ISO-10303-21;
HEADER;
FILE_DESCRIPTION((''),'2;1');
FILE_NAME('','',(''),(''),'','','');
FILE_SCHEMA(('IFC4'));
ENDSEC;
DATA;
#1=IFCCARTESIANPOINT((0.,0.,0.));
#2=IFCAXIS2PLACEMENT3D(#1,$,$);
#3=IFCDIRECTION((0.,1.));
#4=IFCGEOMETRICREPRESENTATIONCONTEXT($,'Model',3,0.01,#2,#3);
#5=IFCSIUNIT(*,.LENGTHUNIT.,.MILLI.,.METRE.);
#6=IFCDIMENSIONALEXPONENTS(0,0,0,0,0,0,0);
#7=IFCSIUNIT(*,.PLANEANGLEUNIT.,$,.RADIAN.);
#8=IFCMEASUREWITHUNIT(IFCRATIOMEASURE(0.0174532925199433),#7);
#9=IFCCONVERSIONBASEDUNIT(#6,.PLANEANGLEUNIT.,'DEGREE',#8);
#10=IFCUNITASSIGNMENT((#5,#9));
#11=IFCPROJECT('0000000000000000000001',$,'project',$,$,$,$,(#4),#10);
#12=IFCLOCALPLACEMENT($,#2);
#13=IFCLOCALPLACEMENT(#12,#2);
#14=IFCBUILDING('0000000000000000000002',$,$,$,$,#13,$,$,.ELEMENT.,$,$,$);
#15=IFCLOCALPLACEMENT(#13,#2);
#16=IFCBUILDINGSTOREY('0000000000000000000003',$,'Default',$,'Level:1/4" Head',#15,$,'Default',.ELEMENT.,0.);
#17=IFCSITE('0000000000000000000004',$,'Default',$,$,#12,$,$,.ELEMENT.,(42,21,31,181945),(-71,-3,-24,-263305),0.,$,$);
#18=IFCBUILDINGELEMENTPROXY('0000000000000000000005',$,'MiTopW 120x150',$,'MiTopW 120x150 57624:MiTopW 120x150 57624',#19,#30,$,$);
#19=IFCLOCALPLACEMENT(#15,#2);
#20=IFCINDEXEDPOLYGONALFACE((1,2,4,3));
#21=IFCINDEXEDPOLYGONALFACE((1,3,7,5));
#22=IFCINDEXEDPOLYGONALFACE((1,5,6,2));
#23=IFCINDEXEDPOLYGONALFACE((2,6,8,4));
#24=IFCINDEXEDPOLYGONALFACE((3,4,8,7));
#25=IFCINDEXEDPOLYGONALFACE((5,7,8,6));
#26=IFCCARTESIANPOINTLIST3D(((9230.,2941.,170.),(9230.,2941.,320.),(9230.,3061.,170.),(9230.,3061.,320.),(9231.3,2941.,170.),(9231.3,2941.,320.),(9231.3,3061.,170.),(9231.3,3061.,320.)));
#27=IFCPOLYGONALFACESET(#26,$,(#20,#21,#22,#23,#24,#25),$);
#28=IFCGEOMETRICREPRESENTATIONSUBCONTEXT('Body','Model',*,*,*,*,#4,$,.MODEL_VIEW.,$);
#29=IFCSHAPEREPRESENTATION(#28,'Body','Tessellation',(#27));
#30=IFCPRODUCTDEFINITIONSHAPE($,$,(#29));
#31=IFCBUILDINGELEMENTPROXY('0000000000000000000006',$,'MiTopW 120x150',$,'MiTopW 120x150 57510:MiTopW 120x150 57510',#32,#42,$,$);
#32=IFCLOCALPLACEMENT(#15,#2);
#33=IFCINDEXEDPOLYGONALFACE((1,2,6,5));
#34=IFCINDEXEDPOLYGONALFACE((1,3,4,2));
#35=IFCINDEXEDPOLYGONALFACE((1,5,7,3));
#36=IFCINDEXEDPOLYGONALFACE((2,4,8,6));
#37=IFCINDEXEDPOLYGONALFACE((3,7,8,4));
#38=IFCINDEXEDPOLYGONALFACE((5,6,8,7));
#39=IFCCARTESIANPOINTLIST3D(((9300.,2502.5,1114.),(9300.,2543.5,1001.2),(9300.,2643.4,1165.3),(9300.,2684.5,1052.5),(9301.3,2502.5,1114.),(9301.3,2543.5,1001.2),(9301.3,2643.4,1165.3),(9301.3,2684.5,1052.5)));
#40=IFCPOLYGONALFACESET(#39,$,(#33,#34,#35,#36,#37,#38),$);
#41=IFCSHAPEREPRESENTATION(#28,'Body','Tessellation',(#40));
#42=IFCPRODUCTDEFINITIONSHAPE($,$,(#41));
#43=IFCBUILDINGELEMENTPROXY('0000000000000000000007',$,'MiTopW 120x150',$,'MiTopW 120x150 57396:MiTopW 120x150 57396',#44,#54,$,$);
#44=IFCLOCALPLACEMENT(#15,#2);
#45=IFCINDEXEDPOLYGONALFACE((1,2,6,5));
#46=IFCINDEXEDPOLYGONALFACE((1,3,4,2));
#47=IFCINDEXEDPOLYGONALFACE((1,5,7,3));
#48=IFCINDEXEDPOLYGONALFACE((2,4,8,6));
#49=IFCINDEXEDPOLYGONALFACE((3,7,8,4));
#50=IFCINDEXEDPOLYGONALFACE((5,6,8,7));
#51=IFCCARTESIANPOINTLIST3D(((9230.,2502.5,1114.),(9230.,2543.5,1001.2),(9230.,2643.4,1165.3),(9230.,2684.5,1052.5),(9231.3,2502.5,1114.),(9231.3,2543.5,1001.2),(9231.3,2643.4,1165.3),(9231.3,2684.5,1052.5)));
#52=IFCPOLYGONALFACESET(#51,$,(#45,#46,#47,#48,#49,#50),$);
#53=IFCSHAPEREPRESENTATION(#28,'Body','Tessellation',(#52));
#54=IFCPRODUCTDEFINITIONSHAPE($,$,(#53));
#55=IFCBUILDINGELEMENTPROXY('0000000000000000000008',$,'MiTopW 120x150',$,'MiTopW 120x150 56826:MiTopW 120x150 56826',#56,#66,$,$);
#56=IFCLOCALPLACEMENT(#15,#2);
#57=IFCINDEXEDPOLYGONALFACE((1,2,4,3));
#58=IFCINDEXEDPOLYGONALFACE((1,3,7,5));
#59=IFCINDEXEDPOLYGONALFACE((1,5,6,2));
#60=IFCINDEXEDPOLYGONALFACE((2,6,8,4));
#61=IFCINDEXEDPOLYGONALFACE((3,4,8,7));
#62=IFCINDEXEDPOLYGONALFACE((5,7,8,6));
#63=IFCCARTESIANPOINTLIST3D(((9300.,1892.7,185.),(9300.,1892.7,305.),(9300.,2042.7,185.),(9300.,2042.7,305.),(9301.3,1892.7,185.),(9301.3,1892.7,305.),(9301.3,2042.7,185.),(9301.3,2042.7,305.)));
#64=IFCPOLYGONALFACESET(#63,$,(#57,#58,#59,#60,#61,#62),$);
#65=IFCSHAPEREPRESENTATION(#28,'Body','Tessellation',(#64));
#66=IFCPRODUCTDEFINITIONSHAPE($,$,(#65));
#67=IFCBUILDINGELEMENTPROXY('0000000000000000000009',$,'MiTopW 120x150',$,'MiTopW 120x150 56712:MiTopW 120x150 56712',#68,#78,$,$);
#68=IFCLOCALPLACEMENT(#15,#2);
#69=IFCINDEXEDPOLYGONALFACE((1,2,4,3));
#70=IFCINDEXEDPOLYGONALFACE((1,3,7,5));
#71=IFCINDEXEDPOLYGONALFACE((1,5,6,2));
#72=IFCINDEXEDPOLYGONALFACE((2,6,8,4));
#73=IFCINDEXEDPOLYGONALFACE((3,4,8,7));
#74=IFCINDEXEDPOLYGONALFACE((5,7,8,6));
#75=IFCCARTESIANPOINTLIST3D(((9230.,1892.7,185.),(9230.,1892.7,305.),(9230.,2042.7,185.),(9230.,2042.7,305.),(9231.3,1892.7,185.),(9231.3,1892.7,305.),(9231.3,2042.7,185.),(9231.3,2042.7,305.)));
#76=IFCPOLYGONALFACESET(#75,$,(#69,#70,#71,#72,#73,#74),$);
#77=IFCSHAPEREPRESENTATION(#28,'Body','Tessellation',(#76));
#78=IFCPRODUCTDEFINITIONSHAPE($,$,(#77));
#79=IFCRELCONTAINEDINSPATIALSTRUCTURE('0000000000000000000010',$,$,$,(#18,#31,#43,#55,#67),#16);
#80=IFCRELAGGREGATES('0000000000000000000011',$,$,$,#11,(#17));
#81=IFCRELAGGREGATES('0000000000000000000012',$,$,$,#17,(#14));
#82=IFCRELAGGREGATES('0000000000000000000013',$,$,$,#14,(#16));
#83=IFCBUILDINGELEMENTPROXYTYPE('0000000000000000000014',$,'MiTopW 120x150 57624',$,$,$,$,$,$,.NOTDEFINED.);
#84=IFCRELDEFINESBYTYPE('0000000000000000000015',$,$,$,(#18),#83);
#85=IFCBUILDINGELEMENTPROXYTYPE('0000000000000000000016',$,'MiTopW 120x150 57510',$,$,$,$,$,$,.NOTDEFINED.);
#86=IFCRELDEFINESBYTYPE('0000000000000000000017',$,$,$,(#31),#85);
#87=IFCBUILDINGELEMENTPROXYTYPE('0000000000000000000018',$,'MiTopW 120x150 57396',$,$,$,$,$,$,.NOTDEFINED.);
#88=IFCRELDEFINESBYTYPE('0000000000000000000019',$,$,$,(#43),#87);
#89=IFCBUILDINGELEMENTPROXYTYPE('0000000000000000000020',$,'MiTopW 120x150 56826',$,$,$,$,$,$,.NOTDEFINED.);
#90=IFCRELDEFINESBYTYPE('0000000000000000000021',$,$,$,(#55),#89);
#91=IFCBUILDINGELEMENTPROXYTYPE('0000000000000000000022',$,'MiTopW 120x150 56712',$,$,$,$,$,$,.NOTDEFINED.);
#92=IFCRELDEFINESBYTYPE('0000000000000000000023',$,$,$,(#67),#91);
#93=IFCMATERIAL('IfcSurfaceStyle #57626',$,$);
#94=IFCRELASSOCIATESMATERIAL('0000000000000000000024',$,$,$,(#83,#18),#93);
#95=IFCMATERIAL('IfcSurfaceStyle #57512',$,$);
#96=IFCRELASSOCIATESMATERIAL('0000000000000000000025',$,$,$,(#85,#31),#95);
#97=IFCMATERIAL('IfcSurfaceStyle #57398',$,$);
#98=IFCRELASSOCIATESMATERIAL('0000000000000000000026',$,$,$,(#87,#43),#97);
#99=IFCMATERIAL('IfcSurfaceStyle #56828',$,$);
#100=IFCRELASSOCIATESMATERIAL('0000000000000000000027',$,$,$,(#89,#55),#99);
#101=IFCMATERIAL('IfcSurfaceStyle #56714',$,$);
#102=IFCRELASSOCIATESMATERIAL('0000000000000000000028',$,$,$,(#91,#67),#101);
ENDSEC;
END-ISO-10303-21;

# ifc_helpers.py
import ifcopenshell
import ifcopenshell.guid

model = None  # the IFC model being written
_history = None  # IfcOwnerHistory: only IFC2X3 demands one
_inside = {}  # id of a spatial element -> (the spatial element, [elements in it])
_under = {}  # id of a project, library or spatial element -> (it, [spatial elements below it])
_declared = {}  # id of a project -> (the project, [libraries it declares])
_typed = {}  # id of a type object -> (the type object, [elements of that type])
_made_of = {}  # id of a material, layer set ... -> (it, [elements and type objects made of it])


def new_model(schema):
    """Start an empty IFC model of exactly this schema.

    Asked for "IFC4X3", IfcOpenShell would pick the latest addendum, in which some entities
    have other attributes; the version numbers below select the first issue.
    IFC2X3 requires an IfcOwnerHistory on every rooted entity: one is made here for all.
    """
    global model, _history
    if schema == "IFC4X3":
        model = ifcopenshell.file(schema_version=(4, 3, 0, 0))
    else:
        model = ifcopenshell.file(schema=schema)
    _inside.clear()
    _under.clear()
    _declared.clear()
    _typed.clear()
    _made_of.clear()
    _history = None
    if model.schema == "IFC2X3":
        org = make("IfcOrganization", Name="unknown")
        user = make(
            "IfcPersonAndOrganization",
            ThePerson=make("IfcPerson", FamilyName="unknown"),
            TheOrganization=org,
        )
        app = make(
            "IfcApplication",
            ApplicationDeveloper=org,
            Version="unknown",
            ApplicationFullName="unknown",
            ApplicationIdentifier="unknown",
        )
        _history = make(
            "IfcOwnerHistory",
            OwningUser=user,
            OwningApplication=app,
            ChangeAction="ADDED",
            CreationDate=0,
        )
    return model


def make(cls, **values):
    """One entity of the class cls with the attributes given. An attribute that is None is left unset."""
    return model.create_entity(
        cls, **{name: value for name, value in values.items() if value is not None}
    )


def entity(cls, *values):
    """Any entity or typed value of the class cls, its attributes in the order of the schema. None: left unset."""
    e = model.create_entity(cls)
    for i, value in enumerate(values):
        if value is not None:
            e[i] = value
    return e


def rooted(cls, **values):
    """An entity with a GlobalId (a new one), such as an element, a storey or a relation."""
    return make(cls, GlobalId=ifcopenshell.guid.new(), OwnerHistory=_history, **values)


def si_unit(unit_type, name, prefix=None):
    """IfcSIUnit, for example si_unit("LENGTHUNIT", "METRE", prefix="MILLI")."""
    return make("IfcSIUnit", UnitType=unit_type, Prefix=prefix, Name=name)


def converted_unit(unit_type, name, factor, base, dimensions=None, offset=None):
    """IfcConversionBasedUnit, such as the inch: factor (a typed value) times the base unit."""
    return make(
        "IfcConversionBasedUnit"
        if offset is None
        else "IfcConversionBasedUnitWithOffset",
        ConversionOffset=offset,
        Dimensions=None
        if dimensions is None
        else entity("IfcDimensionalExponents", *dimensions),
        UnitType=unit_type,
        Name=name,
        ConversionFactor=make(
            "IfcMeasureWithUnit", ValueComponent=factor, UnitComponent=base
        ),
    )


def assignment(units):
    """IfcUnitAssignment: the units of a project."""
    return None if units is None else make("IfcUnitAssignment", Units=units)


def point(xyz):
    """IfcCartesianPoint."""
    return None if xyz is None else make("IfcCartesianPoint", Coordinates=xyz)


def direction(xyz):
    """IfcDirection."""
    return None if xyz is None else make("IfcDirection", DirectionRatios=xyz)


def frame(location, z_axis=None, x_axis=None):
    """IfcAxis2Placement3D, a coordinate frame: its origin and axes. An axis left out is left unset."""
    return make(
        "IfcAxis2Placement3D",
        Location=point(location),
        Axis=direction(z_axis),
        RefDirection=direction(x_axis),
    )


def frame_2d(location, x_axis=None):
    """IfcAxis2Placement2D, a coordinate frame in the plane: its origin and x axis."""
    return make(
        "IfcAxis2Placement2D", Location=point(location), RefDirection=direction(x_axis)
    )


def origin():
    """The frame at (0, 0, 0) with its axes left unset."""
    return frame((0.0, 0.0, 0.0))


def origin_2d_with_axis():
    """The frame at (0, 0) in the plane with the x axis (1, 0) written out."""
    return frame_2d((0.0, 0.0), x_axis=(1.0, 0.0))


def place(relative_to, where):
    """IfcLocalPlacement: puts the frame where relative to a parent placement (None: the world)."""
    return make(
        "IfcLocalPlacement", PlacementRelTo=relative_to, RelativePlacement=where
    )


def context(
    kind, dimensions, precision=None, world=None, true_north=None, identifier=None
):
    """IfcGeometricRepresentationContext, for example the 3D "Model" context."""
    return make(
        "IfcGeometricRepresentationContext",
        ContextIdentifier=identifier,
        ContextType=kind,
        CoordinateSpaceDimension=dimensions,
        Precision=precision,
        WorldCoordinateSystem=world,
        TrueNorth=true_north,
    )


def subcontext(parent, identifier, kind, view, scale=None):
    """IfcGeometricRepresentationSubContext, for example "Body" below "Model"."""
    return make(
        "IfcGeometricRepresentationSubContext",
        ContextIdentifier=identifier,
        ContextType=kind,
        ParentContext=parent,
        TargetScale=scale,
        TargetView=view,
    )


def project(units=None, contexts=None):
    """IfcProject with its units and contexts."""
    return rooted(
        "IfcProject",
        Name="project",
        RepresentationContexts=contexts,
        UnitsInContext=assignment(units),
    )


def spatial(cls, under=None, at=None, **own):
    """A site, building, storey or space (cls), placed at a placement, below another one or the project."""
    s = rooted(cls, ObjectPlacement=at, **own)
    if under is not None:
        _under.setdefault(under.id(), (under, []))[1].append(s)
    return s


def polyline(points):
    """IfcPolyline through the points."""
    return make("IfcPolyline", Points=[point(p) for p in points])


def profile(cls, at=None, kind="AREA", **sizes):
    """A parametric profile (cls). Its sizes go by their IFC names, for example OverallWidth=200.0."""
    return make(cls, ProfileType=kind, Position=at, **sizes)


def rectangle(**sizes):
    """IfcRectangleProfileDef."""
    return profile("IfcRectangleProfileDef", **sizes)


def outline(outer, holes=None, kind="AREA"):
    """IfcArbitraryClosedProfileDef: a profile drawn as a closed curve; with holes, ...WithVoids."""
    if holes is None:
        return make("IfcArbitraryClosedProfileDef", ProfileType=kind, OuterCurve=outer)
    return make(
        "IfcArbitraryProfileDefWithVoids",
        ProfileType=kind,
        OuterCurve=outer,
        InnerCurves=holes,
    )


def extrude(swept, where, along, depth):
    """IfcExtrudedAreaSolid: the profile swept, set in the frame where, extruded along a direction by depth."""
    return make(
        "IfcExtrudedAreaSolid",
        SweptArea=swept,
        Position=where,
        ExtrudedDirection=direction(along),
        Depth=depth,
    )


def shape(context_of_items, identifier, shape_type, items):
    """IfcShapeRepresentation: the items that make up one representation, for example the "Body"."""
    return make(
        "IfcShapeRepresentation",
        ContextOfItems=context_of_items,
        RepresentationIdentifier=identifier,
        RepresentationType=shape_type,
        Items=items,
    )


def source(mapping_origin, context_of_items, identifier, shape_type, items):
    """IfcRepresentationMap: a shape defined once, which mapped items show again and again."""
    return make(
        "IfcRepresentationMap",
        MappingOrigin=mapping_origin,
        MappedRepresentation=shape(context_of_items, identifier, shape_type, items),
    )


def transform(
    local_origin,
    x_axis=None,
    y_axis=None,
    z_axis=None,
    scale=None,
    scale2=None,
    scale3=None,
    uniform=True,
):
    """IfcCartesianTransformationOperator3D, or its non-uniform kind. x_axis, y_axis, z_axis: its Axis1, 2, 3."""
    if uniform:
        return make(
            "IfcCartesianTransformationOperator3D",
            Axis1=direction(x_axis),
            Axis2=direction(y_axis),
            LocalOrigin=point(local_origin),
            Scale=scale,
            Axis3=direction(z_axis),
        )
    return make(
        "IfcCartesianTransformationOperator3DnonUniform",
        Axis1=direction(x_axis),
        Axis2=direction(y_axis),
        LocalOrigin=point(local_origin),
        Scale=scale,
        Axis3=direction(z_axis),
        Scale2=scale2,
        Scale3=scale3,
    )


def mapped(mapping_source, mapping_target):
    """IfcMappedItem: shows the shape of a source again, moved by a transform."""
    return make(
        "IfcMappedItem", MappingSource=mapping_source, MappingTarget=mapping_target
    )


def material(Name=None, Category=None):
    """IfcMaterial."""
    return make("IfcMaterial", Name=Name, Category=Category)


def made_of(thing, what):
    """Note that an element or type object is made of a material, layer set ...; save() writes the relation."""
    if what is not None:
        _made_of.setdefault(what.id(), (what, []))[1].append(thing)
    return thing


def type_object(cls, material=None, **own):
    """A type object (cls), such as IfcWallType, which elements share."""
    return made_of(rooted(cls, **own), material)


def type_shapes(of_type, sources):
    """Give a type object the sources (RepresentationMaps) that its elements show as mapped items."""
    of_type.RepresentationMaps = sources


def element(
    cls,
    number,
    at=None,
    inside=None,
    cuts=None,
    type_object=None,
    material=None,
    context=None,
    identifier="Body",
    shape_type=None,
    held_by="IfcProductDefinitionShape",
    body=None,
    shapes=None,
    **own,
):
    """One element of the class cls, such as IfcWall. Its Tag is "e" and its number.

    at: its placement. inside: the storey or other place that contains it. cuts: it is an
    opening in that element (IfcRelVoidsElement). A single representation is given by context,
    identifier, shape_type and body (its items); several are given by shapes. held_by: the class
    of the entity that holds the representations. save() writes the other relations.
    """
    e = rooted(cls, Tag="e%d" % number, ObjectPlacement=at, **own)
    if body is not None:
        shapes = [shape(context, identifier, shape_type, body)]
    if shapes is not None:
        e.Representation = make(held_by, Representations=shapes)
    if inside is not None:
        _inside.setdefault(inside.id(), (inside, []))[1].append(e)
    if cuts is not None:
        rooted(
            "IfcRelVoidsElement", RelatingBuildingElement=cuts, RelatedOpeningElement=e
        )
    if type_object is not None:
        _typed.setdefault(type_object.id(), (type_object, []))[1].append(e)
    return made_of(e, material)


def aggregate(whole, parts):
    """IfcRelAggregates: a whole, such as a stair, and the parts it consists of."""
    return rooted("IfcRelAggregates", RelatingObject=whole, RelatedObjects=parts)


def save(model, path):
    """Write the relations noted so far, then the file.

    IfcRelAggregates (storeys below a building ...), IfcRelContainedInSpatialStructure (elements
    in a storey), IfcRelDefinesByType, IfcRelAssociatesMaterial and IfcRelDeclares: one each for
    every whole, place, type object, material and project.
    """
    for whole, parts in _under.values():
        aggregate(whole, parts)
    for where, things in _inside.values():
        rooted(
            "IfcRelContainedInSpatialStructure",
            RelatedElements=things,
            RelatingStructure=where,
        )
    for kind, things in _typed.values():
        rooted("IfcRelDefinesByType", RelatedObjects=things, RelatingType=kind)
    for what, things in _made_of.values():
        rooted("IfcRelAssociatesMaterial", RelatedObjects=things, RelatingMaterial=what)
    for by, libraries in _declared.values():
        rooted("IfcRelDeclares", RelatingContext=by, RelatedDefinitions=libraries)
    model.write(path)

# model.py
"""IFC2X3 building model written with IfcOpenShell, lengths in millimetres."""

from ifc_helpers import new_model, entity, si_unit, converted_unit, direction, frame, frame_2d, origin, origin_2d_with_axis, place, context, subcontext, project, spatial, polyline, rectangle, outline, extrude, source, transform, mapped, material, type_object, type_shapes, element, save


model = new_model("IFC2X3")

# Units and contexts
model_context = context("Model", 3, precision=0.01, world=origin(), true_north=direction((0.0, 1.0)))
body_context = subcontext(model_context, "Body", "Model", "MODEL_VIEW")
ifc_project = project(units=[si_unit("LENGTHUNIT", "METRE", prefix="MILLI"), converted_unit("PLANEANGLEUNIT", "DEGREE", entity("IfcRatioMeasure", 0.0174532925199433), si_unit("PLANEANGLEUNIT", "RADIAN"), dimensions=[0, 0, 0, 0, 0, 0, 0])], contexts=[model_context])

# Site, building, storey
site_placement = place(None, origin())
site = spatial("IfcSite", under=ifc_project, at=site_placement, Name="Default", CompositionType="ELEMENT", RefLatitude=(42, 21, 31, 181945), RefLongitude=(-71, -3, -24, -263305), RefElevation=0.0)
building_placement = place(site_placement, origin())
building = spatial("IfcBuilding", under=site, at=building_placement, CompositionType="ELEMENT")
storey_placement = place(building_placement, origin())
storey = spatial("IfcBuildingStorey", under=building, at=storey_placement, Name="Default", ObjectType="Level:1/4\" Head", LongName="Default", CompositionType="ELEMENT", Elevation=0.0)

# Building element proxies
ifc_material_1 = material(Name="IfcSurfaceStyle #57626")
building_element_proxy_type_1 = type_object("IfcBuildingElementProxyType", Name="MiTopW 120x150 57624", PredefinedType="NOTDEFINED", material=ifc_material_1)
shared_shape_1 = source(origin(), body_context, "Body", "SweptSolid", [
    extrude(rectangle(XDim=150.0, YDim=120.0, at=frame_2d((0.0, 0.0), x_axis=(1.0, 0.0))), frame((75.0, 60.0, 0.0), z_axis=(0.0, 0.0, 1.0), x_axis=(-1.0, 0.0, 0.0)), (0.0, 0.0, 1.0), 1.3),
])
type_shapes(building_element_proxy_type_1, [shared_shape_1])
proxy_1_placement = place(building_placement, frame((9231.3, 2941.0, 170.0), z_axis=(-1.0, 0.0, 0.0), x_axis=(0.0, 0.0, 1.0)))
element("IfcBuildingElementProxy", 1, at=proxy_1_placement, inside=storey, type_object=building_element_proxy_type_1, material=ifc_material_1, Name="MiTopW 120x150", ObjectType="MiTopW 120x150 57624:MiTopW 120x150 57624", context=body_context, shape_type="MappedRepresentation", body=[
    mapped(shared_shape_1, transform((0.0, 0.0, 0.0), scale=1.0)),
])
ifc_material_2 = material(Name="IfcSurfaceStyle #57512")
building_element_proxy_type_2 = type_object("IfcBuildingElementProxyType", Name="MiTopW 120x150 57510", PredefinedType="NOTDEFINED", material=ifc_material_2)
shared_shape_2 = source(origin(), body_context, "Body", "SweptSolid", [
    extrude(outline(polyline([(-75.0, -60.0), (75.0, -60.0), (75.0, 60.0), (-75.0, 60.0), (-75.0, -60.0)])), frame((75.0, 60.0, 0.0), z_axis=(0.0, 0.0, 1.0), x_axis=(-1.0, 0.0, 0.0)), (0.0, 0.0, 1.0), 1.3),
])
type_shapes(building_element_proxy_type_2, [shared_shape_2])
proxy_2_placement = place(building_placement, frame((9301.3, 2502.5, 1114.0), z_axis=(-1.0, 0.0, 0.0), x_axis=(0.0, 0.939693, 0.34202)))
element("IfcBuildingElementProxy", 2, at=proxy_2_placement, inside=storey, type_object=building_element_proxy_type_2, material=ifc_material_2, Name="MiTopW 120x150", ObjectType="MiTopW 120x150 57510:MiTopW 120x150 57510", context=body_context, shape_type="MappedRepresentation", body=[
    mapped(shared_shape_2, transform((0.0, 0.0, 0.0), scale=1.0)),
])
ifc_material_3 = material(Name="IfcSurfaceStyle #57398")
building_element_proxy_type_3 = type_object("IfcBuildingElementProxyType", Name="MiTopW 120x150 57396", PredefinedType="NOTDEFINED", material=ifc_material_3)
shared_shape_3 = source(origin(), body_context, "Body", "SweptSolid", [
    extrude(outline(polyline([(-75.0, -60.0), (75.0, -60.0), (75.0, 60.0), (-75.0, 60.0), (-75.0, -60.0)])), frame((75.0, 60.0, 0.0), z_axis=(0.0, 0.0, 1.0), x_axis=(-1.0, 0.0, 0.0)), (0.0, 0.0, 1.0), 1.3),
])
type_shapes(building_element_proxy_type_3, [shared_shape_3])
proxy_3_placement = place(building_placement, frame((9231.3, 2502.5, 1114.0), z_axis=(-1.0, 0.0, 0.0), x_axis=(0.0, 0.939693, 0.34202)))
element("IfcBuildingElementProxy", 3, at=proxy_3_placement, inside=storey, type_object=building_element_proxy_type_3, material=ifc_material_3, Name="MiTopW 120x150", ObjectType="MiTopW 120x150 57396:MiTopW 120x150 57396", context=body_context, shape_type="MappedRepresentation", body=[
    mapped(shared_shape_3, transform((0.0, 0.0, 0.0), scale=1.0)),
])
ifc_material_4 = material(Name="IfcSurfaceStyle #56828")
building_element_proxy_type_4 = type_object("IfcBuildingElementProxyType", Name="MiTopW 120x150 56826", PredefinedType="NOTDEFINED", material=ifc_material_4)
shared_shape_4 = source(origin(), body_context, "Body", "SweptSolid", [
    extrude(rectangle(XDim=150.0, YDim=120.0, at=origin_2d_with_axis()), frame((75.0, 60.0, 0.0), z_axis=(0.0, 0.0, 1.0), x_axis=(-1.0, 0.0, 0.0)), (0.0, 0.0, 1.0), 1.3),
])
type_shapes(building_element_proxy_type_4, [shared_shape_4])
proxy_4_placement = place(building_placement, frame((9301.3, 1892.7, 305.0), z_axis=(-1.0, 0.0, 0.0), x_axis=(0.0, 1.0, 0.0)))
element("IfcBuildingElementProxy", 4, at=proxy_4_placement, inside=storey, type_object=building_element_proxy_type_4, material=ifc_material_4, Name="MiTopW 120x150", ObjectType="MiTopW 120x150 56826:MiTopW 120x150 56826", context=body_context, shape_type="MappedRepresentation", body=[
    mapped(shared_shape_4, transform((0.0, 0.0, 0.0), scale=1.0)),
])
ifc_material_5 = material(Name="IfcSurfaceStyle #56714")
building_element_proxy_type_5 = type_object("IfcBuildingElementProxyType", Name="MiTopW 120x150 56712", PredefinedType="NOTDEFINED", material=ifc_material_5)
shared_shape_5 = source(origin(), body_context, "Body", "SweptSolid", [
    extrude(rectangle(XDim=150.0, YDim=120.0, at=origin_2d_with_axis()), frame((75.0, 60.0, 0.0), z_axis=(0.0, 0.0, 1.0), x_axis=(-1.0, 0.0, 0.0)), (0.0, 0.0, 1.0), 1.3),
])
type_shapes(building_element_proxy_type_5, [shared_shape_5])
proxy_5_placement = place(building_placement, frame((9231.3, 1892.7, 305.0), z_axis=(-1.0, 0.0, 0.0), x_axis=(0.0, 1.0, 0.0)))
element("IfcBuildingElementProxy", 5, at=proxy_5_placement, inside=storey, type_object=building_element_proxy_type_5, material=ifc_material_5, Name="MiTopW 120x150", ObjectType="MiTopW 120x150 56712:MiTopW 120x150 56712", context=body_context, shape_type="MappedRepresentation", body=[
    mapped(shared_shape_5, transform((0.0, 0.0, 0.0), scale=1.0)),
])

save(model, "model.ifc")
